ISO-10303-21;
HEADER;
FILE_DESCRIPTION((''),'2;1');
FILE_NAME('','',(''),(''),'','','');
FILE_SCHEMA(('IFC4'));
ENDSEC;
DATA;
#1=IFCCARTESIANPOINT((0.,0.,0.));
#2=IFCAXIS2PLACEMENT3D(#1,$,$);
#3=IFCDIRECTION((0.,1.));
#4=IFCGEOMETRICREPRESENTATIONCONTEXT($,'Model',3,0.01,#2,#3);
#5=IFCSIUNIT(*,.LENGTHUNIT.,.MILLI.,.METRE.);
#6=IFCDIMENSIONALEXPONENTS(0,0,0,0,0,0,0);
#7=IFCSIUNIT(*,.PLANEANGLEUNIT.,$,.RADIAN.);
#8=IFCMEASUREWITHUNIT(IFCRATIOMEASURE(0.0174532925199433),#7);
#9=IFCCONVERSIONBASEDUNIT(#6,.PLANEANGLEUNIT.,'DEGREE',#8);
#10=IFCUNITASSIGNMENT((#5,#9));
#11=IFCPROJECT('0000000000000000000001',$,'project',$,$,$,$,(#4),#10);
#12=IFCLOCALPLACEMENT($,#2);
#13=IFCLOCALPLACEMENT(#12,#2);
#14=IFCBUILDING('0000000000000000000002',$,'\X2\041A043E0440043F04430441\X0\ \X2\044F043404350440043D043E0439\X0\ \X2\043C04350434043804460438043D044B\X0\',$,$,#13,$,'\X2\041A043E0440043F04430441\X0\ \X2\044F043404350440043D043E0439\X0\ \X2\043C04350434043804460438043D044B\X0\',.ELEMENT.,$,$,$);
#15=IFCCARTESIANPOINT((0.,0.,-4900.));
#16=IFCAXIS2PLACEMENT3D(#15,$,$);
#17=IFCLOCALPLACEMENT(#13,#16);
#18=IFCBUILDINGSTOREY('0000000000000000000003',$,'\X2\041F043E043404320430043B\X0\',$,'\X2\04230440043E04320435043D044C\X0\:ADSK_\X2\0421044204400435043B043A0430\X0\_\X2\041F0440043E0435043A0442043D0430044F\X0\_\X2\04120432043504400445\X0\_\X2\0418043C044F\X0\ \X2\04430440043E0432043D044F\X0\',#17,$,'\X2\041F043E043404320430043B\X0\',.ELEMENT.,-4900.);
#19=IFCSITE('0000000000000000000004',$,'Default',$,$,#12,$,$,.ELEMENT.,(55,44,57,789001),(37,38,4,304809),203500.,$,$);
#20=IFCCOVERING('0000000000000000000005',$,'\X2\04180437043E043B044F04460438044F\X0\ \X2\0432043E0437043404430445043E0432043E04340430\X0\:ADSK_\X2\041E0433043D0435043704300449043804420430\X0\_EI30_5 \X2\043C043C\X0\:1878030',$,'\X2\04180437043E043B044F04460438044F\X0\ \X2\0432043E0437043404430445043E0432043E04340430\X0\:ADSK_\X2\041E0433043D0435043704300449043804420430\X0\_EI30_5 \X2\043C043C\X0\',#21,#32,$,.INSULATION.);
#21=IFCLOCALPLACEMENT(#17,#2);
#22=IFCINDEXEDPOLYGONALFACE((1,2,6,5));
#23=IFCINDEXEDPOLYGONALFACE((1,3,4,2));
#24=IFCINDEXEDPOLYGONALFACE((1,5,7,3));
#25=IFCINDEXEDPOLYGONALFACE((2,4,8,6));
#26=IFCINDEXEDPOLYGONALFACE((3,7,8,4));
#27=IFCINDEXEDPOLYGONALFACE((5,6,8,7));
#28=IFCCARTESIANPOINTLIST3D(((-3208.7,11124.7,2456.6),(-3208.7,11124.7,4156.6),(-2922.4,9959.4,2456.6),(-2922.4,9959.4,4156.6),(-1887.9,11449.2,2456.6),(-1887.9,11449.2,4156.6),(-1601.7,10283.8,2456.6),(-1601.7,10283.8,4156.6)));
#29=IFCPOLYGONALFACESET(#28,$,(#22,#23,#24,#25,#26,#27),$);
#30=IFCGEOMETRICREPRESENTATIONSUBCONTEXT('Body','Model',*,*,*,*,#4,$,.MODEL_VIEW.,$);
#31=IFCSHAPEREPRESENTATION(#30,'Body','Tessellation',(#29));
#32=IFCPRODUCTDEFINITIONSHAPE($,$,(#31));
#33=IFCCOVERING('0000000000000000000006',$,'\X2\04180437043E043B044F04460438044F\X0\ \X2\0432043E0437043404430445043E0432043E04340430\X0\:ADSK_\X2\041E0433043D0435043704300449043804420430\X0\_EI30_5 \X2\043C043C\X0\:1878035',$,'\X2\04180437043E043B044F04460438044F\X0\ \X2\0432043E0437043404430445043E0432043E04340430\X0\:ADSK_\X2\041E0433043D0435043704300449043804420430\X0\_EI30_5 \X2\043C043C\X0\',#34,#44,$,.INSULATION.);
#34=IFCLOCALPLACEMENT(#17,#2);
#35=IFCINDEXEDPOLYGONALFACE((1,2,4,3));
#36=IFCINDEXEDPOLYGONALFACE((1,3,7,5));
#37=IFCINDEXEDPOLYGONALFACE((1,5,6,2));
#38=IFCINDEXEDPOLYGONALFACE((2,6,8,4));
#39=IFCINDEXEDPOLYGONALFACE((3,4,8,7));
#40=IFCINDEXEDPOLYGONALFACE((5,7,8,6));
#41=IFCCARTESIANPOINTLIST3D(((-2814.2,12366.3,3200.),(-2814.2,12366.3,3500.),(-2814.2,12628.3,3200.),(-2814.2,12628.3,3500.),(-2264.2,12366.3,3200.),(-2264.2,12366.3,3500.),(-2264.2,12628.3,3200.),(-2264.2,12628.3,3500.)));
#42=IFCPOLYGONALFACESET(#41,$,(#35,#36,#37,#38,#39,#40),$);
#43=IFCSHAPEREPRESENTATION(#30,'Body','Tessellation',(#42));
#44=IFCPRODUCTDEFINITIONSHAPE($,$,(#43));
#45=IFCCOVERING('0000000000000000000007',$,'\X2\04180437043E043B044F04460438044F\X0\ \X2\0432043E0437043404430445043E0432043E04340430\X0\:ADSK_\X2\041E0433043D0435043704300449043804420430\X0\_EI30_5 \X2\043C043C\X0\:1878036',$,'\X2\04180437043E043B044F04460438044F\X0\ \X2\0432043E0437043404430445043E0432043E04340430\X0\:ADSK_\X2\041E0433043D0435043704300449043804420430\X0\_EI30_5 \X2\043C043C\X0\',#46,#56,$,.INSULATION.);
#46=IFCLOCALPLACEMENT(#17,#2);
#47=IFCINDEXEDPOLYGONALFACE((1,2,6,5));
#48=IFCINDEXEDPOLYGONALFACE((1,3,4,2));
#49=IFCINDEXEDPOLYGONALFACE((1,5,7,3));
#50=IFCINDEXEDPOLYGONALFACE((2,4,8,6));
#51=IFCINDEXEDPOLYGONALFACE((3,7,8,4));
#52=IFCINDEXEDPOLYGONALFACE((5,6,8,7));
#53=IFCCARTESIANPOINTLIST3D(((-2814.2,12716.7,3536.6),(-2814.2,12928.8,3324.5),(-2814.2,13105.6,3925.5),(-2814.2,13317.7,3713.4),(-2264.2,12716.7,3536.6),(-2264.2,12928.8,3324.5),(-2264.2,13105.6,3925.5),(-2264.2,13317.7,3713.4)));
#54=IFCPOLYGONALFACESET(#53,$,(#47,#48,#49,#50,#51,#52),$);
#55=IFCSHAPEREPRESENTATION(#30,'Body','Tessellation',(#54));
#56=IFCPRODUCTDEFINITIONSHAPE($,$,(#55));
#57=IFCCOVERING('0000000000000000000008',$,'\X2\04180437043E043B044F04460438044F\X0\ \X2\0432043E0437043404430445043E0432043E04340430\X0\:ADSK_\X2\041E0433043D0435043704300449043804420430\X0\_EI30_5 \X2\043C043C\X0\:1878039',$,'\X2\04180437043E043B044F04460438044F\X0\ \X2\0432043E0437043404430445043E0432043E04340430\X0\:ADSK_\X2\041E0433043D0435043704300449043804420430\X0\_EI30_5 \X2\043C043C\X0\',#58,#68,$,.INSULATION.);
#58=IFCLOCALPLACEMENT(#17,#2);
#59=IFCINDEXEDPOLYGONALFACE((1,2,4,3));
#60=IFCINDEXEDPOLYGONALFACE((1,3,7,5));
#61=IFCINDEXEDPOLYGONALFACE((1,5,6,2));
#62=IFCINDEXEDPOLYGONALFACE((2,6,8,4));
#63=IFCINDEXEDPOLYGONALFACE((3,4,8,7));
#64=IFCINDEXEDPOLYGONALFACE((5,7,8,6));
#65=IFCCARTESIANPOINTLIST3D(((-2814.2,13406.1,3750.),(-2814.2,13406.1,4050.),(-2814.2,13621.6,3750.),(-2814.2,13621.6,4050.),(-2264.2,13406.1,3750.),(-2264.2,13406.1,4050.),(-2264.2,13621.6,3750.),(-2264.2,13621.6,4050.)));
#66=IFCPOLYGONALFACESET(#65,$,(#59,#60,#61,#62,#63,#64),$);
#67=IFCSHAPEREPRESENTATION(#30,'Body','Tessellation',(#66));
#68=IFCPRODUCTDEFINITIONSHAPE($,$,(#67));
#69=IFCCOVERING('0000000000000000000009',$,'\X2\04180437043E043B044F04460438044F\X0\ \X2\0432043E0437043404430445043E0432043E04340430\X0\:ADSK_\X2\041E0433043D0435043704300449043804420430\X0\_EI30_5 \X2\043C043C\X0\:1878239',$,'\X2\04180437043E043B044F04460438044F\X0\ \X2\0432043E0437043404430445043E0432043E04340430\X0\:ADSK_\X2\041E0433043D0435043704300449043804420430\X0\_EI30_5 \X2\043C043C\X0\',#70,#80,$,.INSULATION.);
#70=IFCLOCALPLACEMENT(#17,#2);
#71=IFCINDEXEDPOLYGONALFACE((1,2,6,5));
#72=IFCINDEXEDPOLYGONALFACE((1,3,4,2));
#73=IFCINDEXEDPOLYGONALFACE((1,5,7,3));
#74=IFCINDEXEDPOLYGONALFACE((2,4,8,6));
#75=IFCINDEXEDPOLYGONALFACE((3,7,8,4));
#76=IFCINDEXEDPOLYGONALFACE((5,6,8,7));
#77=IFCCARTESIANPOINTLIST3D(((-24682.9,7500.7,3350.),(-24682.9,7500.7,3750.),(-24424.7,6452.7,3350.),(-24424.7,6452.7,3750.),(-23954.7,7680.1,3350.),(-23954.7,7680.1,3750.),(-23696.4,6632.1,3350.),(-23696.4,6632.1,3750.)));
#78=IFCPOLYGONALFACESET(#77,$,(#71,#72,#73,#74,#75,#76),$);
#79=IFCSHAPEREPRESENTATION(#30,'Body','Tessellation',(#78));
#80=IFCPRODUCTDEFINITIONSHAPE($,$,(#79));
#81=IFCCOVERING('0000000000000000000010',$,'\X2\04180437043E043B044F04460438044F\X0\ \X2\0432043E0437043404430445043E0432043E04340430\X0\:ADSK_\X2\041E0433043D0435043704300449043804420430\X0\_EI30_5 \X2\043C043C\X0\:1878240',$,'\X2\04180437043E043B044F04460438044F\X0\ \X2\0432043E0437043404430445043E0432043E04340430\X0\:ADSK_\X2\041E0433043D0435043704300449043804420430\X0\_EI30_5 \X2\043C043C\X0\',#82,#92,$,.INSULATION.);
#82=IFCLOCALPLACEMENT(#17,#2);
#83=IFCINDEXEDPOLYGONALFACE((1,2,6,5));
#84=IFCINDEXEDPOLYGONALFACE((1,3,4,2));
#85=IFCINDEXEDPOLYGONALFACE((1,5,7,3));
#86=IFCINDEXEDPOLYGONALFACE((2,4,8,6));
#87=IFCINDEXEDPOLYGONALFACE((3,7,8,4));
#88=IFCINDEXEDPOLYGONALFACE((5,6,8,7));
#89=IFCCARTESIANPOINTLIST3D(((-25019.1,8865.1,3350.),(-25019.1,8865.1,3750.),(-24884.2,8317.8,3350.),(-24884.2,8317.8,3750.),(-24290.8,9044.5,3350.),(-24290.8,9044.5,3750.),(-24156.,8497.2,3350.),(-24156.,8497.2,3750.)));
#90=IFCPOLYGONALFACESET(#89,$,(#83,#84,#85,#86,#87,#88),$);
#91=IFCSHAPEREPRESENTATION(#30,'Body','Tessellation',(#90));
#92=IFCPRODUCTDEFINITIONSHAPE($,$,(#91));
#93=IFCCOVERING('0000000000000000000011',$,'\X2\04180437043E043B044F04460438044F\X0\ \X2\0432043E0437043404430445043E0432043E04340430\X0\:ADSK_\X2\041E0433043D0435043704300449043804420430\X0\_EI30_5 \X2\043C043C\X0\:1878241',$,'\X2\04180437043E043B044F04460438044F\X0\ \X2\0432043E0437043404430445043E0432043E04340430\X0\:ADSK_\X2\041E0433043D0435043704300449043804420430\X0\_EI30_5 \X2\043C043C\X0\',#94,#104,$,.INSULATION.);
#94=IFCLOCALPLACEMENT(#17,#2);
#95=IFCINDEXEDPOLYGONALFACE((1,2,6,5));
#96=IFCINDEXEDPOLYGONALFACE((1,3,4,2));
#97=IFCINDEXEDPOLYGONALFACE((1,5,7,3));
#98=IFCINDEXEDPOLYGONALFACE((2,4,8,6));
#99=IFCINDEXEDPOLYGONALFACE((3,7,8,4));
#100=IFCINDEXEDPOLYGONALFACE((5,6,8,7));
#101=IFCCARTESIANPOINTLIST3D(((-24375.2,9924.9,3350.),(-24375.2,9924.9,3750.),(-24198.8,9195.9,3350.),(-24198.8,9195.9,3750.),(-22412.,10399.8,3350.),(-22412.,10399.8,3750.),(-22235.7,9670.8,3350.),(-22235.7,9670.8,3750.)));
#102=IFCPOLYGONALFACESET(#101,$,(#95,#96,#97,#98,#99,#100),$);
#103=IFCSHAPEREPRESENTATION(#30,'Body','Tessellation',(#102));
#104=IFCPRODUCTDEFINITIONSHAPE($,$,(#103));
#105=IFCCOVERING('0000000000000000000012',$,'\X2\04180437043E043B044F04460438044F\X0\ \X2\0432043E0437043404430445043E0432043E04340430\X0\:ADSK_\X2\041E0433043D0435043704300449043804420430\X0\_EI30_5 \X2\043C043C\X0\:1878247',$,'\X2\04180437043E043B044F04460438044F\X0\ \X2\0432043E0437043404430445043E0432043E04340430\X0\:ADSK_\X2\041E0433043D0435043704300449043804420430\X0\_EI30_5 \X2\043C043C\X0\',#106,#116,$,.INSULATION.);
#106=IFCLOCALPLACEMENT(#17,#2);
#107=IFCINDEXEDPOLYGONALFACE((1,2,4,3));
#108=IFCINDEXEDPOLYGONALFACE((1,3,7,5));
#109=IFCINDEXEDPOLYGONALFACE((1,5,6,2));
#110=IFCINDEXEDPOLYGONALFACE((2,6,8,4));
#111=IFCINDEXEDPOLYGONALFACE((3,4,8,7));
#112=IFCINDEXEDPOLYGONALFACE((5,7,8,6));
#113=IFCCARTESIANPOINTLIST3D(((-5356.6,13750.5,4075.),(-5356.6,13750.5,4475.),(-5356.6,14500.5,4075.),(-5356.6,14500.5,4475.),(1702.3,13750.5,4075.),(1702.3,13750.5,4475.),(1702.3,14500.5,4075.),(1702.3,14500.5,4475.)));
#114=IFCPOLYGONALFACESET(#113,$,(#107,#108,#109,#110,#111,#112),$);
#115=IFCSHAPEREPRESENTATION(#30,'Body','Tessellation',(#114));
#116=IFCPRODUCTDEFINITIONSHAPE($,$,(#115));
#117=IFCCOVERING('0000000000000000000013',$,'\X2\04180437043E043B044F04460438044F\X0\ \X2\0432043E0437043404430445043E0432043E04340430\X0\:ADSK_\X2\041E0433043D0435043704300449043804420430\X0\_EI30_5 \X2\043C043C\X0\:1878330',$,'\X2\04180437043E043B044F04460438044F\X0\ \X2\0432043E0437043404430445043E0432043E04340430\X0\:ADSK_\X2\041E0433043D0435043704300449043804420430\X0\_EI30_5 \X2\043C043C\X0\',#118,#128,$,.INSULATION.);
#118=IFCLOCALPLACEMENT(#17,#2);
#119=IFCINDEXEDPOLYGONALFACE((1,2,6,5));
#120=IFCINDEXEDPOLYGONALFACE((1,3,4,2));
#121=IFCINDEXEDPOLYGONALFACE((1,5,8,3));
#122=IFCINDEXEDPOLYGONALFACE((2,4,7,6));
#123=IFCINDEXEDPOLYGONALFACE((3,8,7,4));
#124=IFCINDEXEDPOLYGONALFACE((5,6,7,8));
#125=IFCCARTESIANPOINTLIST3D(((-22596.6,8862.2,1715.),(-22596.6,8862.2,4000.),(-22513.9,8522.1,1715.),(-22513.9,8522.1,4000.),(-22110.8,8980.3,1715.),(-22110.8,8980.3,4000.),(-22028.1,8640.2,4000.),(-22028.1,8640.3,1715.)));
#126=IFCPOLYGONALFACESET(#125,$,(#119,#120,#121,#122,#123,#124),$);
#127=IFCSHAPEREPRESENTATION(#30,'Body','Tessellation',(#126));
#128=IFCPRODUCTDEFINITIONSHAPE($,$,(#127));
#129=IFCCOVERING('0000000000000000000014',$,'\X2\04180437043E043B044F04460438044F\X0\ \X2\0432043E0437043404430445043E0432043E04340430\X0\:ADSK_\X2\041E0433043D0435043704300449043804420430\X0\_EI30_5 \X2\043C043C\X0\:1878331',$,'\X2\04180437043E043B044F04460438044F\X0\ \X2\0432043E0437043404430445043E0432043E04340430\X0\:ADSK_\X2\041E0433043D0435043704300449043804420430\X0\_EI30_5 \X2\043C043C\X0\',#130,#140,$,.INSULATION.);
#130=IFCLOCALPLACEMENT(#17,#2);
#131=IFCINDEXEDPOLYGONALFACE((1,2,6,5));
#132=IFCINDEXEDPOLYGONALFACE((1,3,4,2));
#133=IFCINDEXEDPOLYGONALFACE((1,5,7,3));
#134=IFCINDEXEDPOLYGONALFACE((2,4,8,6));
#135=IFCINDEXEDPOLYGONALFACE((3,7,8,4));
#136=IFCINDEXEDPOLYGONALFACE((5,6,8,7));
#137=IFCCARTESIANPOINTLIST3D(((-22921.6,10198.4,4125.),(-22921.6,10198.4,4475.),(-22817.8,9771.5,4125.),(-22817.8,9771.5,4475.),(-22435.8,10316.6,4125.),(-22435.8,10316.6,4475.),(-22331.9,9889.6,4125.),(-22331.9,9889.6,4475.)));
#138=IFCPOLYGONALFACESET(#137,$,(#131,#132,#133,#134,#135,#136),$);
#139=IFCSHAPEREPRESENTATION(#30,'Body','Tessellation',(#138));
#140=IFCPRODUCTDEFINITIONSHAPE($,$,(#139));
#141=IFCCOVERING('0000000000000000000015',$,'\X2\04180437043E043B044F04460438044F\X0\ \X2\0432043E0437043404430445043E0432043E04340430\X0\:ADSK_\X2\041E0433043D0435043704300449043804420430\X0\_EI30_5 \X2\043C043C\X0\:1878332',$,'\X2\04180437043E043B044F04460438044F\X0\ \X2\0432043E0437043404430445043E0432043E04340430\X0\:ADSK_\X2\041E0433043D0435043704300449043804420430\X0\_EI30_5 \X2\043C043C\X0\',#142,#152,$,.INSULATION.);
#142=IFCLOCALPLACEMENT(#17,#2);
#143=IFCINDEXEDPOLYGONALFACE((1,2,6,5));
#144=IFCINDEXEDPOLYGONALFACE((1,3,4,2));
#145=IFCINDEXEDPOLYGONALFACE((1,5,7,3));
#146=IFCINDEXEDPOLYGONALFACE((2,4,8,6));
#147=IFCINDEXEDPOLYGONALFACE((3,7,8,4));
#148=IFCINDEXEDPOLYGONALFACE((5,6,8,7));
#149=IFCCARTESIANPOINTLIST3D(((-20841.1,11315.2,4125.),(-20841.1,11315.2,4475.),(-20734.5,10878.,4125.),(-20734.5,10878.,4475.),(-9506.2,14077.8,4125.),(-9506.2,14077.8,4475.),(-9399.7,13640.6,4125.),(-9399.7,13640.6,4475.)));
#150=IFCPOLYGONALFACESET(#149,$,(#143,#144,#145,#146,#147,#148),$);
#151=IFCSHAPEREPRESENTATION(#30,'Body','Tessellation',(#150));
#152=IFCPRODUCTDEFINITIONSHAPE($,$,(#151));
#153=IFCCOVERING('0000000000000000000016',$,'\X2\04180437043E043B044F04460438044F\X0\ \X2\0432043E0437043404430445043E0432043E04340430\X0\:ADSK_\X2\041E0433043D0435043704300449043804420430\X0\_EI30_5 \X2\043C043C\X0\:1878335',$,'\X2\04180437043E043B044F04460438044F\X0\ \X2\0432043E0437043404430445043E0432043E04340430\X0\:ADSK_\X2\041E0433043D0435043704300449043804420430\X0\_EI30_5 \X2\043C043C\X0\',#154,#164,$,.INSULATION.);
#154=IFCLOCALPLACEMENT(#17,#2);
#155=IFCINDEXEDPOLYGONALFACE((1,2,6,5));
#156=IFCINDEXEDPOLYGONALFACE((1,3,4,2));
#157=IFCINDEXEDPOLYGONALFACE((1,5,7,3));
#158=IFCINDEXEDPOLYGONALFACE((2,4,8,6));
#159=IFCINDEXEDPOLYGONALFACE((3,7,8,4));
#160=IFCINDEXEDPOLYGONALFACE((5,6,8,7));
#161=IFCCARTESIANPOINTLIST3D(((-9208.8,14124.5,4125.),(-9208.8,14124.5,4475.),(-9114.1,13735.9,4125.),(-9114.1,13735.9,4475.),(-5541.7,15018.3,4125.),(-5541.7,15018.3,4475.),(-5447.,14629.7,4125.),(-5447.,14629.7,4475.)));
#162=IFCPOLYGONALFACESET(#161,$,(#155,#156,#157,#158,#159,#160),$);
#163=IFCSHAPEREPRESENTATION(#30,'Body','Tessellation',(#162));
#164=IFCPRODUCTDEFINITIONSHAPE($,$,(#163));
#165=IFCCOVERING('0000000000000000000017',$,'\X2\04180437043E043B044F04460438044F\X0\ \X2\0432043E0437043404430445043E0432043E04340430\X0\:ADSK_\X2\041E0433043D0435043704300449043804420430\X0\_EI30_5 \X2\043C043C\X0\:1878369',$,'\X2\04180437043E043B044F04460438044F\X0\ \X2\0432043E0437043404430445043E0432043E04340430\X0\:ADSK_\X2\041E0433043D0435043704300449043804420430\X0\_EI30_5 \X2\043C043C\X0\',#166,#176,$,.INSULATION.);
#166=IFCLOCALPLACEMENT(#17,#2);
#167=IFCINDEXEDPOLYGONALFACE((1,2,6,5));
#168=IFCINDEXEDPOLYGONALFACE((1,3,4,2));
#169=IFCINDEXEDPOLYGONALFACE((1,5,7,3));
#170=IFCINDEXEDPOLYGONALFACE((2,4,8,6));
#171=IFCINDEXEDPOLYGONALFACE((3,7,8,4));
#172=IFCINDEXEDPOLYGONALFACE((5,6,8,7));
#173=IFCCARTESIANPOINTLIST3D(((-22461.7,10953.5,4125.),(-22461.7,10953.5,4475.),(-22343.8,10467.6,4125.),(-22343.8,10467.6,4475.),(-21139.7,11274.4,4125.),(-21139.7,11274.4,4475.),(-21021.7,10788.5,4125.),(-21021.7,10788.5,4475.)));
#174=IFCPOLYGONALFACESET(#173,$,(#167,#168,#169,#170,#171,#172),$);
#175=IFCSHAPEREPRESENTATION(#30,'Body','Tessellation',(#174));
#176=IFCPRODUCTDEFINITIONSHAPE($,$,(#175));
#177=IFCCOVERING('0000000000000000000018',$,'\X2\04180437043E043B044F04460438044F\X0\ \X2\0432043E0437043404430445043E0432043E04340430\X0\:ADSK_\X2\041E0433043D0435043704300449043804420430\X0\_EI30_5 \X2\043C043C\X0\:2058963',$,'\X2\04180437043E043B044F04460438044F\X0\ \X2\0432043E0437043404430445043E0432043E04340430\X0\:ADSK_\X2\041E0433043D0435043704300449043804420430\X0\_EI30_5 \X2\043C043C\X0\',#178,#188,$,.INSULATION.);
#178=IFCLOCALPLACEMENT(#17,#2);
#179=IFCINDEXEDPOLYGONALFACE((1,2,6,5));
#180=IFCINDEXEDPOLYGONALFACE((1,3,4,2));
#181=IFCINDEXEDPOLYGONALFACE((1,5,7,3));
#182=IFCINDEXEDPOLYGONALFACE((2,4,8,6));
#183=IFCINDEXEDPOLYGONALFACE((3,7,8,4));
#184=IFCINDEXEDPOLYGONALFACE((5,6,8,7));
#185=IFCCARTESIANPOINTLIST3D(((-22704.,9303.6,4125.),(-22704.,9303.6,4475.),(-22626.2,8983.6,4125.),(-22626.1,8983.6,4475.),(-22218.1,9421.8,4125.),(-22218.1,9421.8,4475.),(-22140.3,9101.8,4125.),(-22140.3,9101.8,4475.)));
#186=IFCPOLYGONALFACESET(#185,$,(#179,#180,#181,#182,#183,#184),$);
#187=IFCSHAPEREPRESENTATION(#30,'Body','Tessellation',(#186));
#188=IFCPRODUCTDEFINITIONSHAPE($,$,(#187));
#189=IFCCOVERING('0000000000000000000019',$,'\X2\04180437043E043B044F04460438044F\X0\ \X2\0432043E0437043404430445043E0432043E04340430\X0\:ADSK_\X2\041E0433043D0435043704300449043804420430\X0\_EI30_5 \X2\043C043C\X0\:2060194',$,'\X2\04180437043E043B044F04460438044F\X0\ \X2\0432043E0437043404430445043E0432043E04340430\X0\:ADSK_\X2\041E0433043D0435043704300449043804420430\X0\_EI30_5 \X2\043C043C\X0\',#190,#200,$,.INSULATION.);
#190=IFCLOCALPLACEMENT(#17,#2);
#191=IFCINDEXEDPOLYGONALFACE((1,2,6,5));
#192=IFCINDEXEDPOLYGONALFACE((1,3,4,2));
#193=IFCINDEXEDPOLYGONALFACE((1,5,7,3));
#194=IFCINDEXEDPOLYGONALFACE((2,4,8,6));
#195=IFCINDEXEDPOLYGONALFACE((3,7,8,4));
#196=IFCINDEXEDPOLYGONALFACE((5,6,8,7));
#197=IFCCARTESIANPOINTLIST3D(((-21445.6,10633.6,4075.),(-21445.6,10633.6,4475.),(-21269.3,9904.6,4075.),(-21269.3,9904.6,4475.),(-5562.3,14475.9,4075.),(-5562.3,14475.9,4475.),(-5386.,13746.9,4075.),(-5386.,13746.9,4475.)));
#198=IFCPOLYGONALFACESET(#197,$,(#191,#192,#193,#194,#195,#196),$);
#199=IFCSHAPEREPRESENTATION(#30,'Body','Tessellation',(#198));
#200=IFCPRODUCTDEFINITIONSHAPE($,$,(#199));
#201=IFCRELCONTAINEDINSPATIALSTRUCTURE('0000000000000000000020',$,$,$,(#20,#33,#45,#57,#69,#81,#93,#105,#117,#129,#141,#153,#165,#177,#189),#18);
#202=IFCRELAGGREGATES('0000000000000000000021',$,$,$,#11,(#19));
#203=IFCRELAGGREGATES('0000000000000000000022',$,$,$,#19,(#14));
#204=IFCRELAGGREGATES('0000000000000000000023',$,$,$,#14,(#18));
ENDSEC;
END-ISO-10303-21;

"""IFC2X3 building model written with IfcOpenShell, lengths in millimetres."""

from ifc_helpers import new_model, entity, si_unit, converted_unit, direction, frame, origin, origin_2d_with_axis, place, context, subcontext, project, spatial, rectangle, extrude, element, save


model = new_model("IFC2X3")

# Units and contexts
model_context = context("Model", 3, precision=0.01, world=origin(), true_north=direction((0.0, 1.0)))
body_context = subcontext(model_context, "Body", "Model", "MODEL_VIEW")
ifc_project = project(units=[si_unit("LENGTHUNIT", "METRE", prefix="MILLI"), converted_unit("PLANEANGLEUNIT", "DEGREE", entity("IfcRatioMeasure", 0.0174532925199433), si_unit("PLANEANGLEUNIT", "RADIAN"), dimensions=[0, 0, 0, 0, 0, 0, 0])], contexts=[model_context])

# Site, building, storey
site_placement = place(None, origin())
site = spatial("IfcSite", under=ifc_project, at=site_placement, Name="Default", CompositionType="ELEMENT", RefLatitude=(55, 44, 57, 789001), RefLongitude=(37, 38, 4, 304809), RefElevation=203500.0)
building_placement = place(site_placement, origin())
building = spatial("IfcBuilding", under=site, at=building_placement, Name="Корпус ядерной медицины", LongName="Корпус ядерной медицины", CompositionType="ELEMENT")
storey_placement = place(building_placement, frame((0.0, 0.0, -4900.0)))
storey = spatial("IfcBuildingStorey", under=building, at=storey_placement, Name="Подвал", ObjectType="Уровень:ADSK_Стрелка_Проектная_Вверх_Имя уровня", LongName="Подвал", CompositionType="ELEMENT", Elevation=-4900.0)

# Coverings
covering_1_placement = place(storey_placement, frame((-3208.7, 9959.4, 2456.6)))
element("IfcCovering", 1, at=covering_1_placement, inside=storey, Name="Изоляция воздуховода:ADSK_Огнезащита_EI30_5 мм:1878030", ObjectType="Изоляция воздуховода:ADSK_Огнезащита_EI30_5 мм", PredefinedType="INSULATION", context=body_context, shape_type="SweptSolid", body=[
    extrude(rectangle(XDim=1360.0, YDim=1200.0, at=origin_2d_with_axis()), frame((803.5, 744.9, 0.0), z_axis=(0.0, 0.0, 1.0), x_axis=(-0.971126, -0.238567, 0.0)), (0.0, 0.0, 1.0), 1700.0),
])
covering_2_placement = place(storey_placement, frame((-2814.2, 12366.3, 3200.0)))
element("IfcCovering", 2, at=covering_2_placement, inside=storey, Name="Изоляция воздуховода:ADSK_Огнезащита_EI30_5 мм:1878035", ObjectType="Изоляция воздуховода:ADSK_Огнезащита_EI30_5 мм", PredefinedType="INSULATION", context=body_context, shape_type="SweptSolid", body=[
    extrude(rectangle(XDim=262.0, YDim=550.0, at=origin_2d_with_axis()), frame((275.0, 131.0, 0.0), z_axis=(0.0, 0.0, 1.0), x_axis=(0.0, 1.0, 0.0)), (0.0, 0.0, 1.0), 300.0),
])
covering_3_placement = place(storey_placement, frame((-2814.2, 12716.7, 3324.5)))
element("IfcCovering", 3, at=covering_3_placement, inside=storey, Name="Изоляция воздуховода:ADSK_Огнезащита_EI30_5 мм:1878036", ObjectType="Изоляция воздуховода:ADSK_Огнезащита_EI30_5 мм", PredefinedType="INSULATION", context=body_context, shape_type="SweptSolid", body=[
    extrude(rectangle(XDim=550.0, YDim=300.0, at=origin_2d_with_axis()), frame((0.0, 300.5, 300.5), z_axis=(1.0, 0.0, 0.0), x_axis=(0.0, 0.707107, 0.707107)), (0.0, 0.0, 1.0), 550.0),
])
covering_4_placement = place(storey_placement, frame((-2814.2, 13406.1, 3750.0)))
element("IfcCovering", 4, at=covering_4_placement, inside=storey, Name="Изоляция воздуховода:ADSK_Огнезащита_EI30_5 мм:1878039", ObjectType="Изоляция воздуховода:ADSK_Огнезащита_EI30_5 мм", PredefinedType="INSULATION", context=body_context, shape_type="SweptSolid", body=[
    extrude(rectangle(XDim=215.5, YDim=550.0, at=origin_2d_with_axis()), frame((275.0, 107.7, 0.0), z_axis=(0.0, 0.0, 1.0), x_axis=(0.0, 1.0, 0.0)), (0.0, 0.0, 1.0), 300.0),
])
covering_5_placement = place(storey_placement, frame((-24682.9, 6452.7, 3350.0)))
element("IfcCovering", 5, at=covering_5_placement, inside=storey, Name="Изоляция воздуховода:ADSK_Огнезащита_EI30_5 мм:1878239", ObjectType="Изоляция воздуховода:ADSK_Огнезащита_EI30_5 мм", PredefinedType="INSULATION", context=body_context, shape_type="SweptSolid", body=[
    extrude(rectangle(XDim=1079.4, YDim=750.0, at=origin_2d_with_axis()), frame((493.2, 613.7, 0.0), z_axis=(0.0, 0.0, 1.0), x_axis=(-0.239235, 0.970962, 0.0)), (0.0, 0.0, 1.0), 400.0),
])
covering_6_placement = place(storey_placement, frame((-25019.1, 8317.8, 3350.0)))
element("IfcCovering", 6, at=covering_6_placement, inside=storey, Name="Изоляция воздуховода:ADSK_Огнезащита_EI30_5 мм:1878240", ObjectType="Изоляция воздуховода:ADSK_Огнезащита_EI30_5 мм", PredefinedType="INSULATION", context=body_context, shape_type="SweptSolid", body=[
    extrude(rectangle(XDim=563.6, YDim=750.0, at=origin_2d_with_axis()), frame((431.5, 363.4, 0.0), z_axis=(0.0, 0.0, 1.0), x_axis=(-0.23924, 0.97096, 0.0)), (0.0, 0.0, 1.0), 400.0),
])
covering_7_placement = place(storey_placement, frame((-24375.2, 9195.9, 3350.0)))
element("IfcCovering", 7, at=covering_7_placement, inside=storey, Name="Изоляция воздуховода:ADSK_Огнезащита_EI30_5 мм:1878241", ObjectType="Изоляция воздуховода:ADSK_Огнезащита_EI30_5 мм", PredefinedType="INSULATION", context=body_context, shape_type="SweptSolid", body=[
    extrude(rectangle(XDim=2019.8, YDim=750.0, at=origin_2d_with_axis()), frame((1069.8, 602.0, 0.0), z_axis=(0.0, 0.0, 1.0), x_axis=(0.971964, 0.23513, 0.0)), (0.0, 0.0, 1.0), 400.0),
])
covering_8_placement = place(storey_placement, frame((-5356.6, 13750.5, 4075.0)))
element("IfcCovering", 8, at=covering_8_placement, inside=storey, Name="Изоляция воздуховода:ADSK_Огнезащита_EI30_5 мм:1878247", ObjectType="Изоляция воздуховода:ADSK_Огнезащита_EI30_5 мм", PredefinedType="INSULATION", context=body_context, shape_type="SweptSolid", body=[
    extrude(rectangle(XDim=7058.8, YDim=750.0, at=origin_2d_with_axis()), frame((3529.4, 375.0, 0.0), z_axis=(0.0, 0.0, 1.0), x_axis=(-1.0, 0.0, 0.0)), (0.0, 0.0, 1.0), 400.0),
])
covering_9_placement = place(storey_placement, frame((-22596.6, 8522.1, 1715.0)))
element("IfcCovering", 9, at=covering_9_placement, inside=storey, Name="Изоляция воздуховода:ADSK_Огнезащита_EI30_5 мм:1878330", ObjectType="Изоляция воздуховода:ADSK_Огнезащита_EI30_5 мм", PredefinedType="INSULATION", context=body_context, shape_type="SweptSolid", body=[
    extrude(rectangle(XDim=350.0, YDim=500.0, at=origin_2d_with_axis()), frame((284.3, 229.1, 0.0), z_axis=(0.000001, -0.000005, 1.0), x_axis=(0.236338, -0.971671, -0.000006)), (0.0, 0.0, 1.0), 2285.0),
])
covering_10_placement = place(storey_placement, frame((-22921.6, 9771.5, 4125.0)))
element("IfcCovering", 10, at=covering_10_placement, inside=storey, Name="Изоляция воздуховода:ADSK_Огнезащита_EI30_5 мм:1878331", ObjectType="Изоляция воздуховода:ADSK_Огнезащита_EI30_5 мм", PredefinedType="INSULATION", context=body_context, shape_type="SweptSolid", body=[
    extrude(rectangle(XDim=439.4, YDim=500.0, at=origin_2d_with_axis()), frame((294.8, 272.6, 0.0), z_axis=(0.000006, -0.000025, 1.0), x_axis=(0.236318, -0.971676, -0.000026)), (0.0, 0.0, 1.0), 350.0),
])
covering_11_placement = place(storey_placement, frame((-20841.1, 10878.0, 4125.0)))
element("IfcCovering", 11, at=covering_11_placement, inside=storey, Name="Изоляция воздуховода:ADSK_Огнезащита_EI30_5 мм:1878332", ObjectType="Изоляция воздуховода:ADSK_Огнезащита_EI30_5 мм", PredefinedType="INSULATION", context=body_context, shape_type="SweptSolid", body=[
    extrude(rectangle(XDim=11666.7, YDim=450.0, at=origin_2d_with_axis()), frame((5720.7, 1599.9, 0.0), z_axis=(0.0, 0.0, 1.0), x_axis=(0.97156, 0.236794, 0.0)), (0.0, 0.0, 1.0), 350.0),
])
covering_12_placement = place(storey_placement, frame((-9208.8, 13735.9, 4125.0)))
element("IfcCovering", 12, at=covering_12_placement, inside=storey, Name="Изоляция воздуховода:ADSK_Огнезащита_EI30_5 мм:1878335", ObjectType="Изоляция воздуховода:ADSK_Огнезащита_EI30_5 мм", PredefinedType="INSULATION", context=body_context, shape_type="SweptSolid", body=[
    extrude(rectangle(XDim=3774.4, YDim=400.0, at=origin_2d_with_axis()), frame((1880.9, 641.2, 0.0), z_axis=(0.0, 0.0, 1.0), x_axis=(0.97156, 0.236794, 0.0)), (0.0, 0.0, 1.0), 350.0),
])
covering_13_placement = place(storey_placement, frame((-22461.7, 10467.6, 4125.0)))
element("IfcCovering", 13, at=covering_13_placement, inside=storey, Name="Изоляция воздуховода:ADSK_Огнезащита_EI30_5 мм:1878369", ObjectType="Изоляция воздуховода:ADSK_Огнезащита_EI30_5 мм", PredefinedType="INSULATION", context=body_context, shape_type="SweptSolid", body=[
    extrude(rectangle(XDim=1360.4, YDim=500.0, at=origin_2d_with_axis()), frame((720.0, 403.4, 0.0), z_axis=(0.0, 0.0, 1.0), x_axis=(-0.971788, -0.235858, 0.0)), (0.0, 0.0, 1.0), 350.0),
])
covering_14_placement = place(storey_placement, frame((-22704.0, 8983.6, 4124.9)))
element("IfcCovering", 14, at=covering_14_placement, inside=storey, Name="Изоляция воздуховода:ADSK_Огнезащита_EI30_5 мм:2058963", ObjectType="Изоляция воздуховода:ADSK_Огнезащита_EI30_5 мм", PredefinedType="INSULATION", context=body_context, shape_type="SweptSolid", body=[
    extrude(rectangle(XDim=329.3, YDim=500.0, at=origin_2d_with_axis()), frame((281.8, 219.1, 0.0), z_axis=(0.000009, -0.000038, 1.0), x_axis=(0.236338, -0.971671, -0.000039)), (0.0, 0.0, 1.0), 350.0),
])
covering_15_placement = place(storey_placement, frame((-21445.7, 9904.6, 4075.0)))
element("IfcCovering", 15, at=covering_15_placement, inside=storey, Name="Изоляция воздуховода:ADSK_Огнезащита_EI30_5 мм:2060194", ObjectType="Изоляция воздуховода:ADSK_Огнезащита_EI30_5 мм", PredefinedType="INSULATION", context=body_context, shape_type="SweptSolid", body=[
    extrude(rectangle(XDim=16341.5, YDim=750.0, at=origin_2d_with_axis()), frame((8029.8, 2285.7, 0.0), z_axis=(0.0, 0.0, 1.0), x_axis=(0.971964, 0.23513, 0.0)), (0.0, 0.0, 1.0), 400.0),
])

save(model, "model.ifc")
